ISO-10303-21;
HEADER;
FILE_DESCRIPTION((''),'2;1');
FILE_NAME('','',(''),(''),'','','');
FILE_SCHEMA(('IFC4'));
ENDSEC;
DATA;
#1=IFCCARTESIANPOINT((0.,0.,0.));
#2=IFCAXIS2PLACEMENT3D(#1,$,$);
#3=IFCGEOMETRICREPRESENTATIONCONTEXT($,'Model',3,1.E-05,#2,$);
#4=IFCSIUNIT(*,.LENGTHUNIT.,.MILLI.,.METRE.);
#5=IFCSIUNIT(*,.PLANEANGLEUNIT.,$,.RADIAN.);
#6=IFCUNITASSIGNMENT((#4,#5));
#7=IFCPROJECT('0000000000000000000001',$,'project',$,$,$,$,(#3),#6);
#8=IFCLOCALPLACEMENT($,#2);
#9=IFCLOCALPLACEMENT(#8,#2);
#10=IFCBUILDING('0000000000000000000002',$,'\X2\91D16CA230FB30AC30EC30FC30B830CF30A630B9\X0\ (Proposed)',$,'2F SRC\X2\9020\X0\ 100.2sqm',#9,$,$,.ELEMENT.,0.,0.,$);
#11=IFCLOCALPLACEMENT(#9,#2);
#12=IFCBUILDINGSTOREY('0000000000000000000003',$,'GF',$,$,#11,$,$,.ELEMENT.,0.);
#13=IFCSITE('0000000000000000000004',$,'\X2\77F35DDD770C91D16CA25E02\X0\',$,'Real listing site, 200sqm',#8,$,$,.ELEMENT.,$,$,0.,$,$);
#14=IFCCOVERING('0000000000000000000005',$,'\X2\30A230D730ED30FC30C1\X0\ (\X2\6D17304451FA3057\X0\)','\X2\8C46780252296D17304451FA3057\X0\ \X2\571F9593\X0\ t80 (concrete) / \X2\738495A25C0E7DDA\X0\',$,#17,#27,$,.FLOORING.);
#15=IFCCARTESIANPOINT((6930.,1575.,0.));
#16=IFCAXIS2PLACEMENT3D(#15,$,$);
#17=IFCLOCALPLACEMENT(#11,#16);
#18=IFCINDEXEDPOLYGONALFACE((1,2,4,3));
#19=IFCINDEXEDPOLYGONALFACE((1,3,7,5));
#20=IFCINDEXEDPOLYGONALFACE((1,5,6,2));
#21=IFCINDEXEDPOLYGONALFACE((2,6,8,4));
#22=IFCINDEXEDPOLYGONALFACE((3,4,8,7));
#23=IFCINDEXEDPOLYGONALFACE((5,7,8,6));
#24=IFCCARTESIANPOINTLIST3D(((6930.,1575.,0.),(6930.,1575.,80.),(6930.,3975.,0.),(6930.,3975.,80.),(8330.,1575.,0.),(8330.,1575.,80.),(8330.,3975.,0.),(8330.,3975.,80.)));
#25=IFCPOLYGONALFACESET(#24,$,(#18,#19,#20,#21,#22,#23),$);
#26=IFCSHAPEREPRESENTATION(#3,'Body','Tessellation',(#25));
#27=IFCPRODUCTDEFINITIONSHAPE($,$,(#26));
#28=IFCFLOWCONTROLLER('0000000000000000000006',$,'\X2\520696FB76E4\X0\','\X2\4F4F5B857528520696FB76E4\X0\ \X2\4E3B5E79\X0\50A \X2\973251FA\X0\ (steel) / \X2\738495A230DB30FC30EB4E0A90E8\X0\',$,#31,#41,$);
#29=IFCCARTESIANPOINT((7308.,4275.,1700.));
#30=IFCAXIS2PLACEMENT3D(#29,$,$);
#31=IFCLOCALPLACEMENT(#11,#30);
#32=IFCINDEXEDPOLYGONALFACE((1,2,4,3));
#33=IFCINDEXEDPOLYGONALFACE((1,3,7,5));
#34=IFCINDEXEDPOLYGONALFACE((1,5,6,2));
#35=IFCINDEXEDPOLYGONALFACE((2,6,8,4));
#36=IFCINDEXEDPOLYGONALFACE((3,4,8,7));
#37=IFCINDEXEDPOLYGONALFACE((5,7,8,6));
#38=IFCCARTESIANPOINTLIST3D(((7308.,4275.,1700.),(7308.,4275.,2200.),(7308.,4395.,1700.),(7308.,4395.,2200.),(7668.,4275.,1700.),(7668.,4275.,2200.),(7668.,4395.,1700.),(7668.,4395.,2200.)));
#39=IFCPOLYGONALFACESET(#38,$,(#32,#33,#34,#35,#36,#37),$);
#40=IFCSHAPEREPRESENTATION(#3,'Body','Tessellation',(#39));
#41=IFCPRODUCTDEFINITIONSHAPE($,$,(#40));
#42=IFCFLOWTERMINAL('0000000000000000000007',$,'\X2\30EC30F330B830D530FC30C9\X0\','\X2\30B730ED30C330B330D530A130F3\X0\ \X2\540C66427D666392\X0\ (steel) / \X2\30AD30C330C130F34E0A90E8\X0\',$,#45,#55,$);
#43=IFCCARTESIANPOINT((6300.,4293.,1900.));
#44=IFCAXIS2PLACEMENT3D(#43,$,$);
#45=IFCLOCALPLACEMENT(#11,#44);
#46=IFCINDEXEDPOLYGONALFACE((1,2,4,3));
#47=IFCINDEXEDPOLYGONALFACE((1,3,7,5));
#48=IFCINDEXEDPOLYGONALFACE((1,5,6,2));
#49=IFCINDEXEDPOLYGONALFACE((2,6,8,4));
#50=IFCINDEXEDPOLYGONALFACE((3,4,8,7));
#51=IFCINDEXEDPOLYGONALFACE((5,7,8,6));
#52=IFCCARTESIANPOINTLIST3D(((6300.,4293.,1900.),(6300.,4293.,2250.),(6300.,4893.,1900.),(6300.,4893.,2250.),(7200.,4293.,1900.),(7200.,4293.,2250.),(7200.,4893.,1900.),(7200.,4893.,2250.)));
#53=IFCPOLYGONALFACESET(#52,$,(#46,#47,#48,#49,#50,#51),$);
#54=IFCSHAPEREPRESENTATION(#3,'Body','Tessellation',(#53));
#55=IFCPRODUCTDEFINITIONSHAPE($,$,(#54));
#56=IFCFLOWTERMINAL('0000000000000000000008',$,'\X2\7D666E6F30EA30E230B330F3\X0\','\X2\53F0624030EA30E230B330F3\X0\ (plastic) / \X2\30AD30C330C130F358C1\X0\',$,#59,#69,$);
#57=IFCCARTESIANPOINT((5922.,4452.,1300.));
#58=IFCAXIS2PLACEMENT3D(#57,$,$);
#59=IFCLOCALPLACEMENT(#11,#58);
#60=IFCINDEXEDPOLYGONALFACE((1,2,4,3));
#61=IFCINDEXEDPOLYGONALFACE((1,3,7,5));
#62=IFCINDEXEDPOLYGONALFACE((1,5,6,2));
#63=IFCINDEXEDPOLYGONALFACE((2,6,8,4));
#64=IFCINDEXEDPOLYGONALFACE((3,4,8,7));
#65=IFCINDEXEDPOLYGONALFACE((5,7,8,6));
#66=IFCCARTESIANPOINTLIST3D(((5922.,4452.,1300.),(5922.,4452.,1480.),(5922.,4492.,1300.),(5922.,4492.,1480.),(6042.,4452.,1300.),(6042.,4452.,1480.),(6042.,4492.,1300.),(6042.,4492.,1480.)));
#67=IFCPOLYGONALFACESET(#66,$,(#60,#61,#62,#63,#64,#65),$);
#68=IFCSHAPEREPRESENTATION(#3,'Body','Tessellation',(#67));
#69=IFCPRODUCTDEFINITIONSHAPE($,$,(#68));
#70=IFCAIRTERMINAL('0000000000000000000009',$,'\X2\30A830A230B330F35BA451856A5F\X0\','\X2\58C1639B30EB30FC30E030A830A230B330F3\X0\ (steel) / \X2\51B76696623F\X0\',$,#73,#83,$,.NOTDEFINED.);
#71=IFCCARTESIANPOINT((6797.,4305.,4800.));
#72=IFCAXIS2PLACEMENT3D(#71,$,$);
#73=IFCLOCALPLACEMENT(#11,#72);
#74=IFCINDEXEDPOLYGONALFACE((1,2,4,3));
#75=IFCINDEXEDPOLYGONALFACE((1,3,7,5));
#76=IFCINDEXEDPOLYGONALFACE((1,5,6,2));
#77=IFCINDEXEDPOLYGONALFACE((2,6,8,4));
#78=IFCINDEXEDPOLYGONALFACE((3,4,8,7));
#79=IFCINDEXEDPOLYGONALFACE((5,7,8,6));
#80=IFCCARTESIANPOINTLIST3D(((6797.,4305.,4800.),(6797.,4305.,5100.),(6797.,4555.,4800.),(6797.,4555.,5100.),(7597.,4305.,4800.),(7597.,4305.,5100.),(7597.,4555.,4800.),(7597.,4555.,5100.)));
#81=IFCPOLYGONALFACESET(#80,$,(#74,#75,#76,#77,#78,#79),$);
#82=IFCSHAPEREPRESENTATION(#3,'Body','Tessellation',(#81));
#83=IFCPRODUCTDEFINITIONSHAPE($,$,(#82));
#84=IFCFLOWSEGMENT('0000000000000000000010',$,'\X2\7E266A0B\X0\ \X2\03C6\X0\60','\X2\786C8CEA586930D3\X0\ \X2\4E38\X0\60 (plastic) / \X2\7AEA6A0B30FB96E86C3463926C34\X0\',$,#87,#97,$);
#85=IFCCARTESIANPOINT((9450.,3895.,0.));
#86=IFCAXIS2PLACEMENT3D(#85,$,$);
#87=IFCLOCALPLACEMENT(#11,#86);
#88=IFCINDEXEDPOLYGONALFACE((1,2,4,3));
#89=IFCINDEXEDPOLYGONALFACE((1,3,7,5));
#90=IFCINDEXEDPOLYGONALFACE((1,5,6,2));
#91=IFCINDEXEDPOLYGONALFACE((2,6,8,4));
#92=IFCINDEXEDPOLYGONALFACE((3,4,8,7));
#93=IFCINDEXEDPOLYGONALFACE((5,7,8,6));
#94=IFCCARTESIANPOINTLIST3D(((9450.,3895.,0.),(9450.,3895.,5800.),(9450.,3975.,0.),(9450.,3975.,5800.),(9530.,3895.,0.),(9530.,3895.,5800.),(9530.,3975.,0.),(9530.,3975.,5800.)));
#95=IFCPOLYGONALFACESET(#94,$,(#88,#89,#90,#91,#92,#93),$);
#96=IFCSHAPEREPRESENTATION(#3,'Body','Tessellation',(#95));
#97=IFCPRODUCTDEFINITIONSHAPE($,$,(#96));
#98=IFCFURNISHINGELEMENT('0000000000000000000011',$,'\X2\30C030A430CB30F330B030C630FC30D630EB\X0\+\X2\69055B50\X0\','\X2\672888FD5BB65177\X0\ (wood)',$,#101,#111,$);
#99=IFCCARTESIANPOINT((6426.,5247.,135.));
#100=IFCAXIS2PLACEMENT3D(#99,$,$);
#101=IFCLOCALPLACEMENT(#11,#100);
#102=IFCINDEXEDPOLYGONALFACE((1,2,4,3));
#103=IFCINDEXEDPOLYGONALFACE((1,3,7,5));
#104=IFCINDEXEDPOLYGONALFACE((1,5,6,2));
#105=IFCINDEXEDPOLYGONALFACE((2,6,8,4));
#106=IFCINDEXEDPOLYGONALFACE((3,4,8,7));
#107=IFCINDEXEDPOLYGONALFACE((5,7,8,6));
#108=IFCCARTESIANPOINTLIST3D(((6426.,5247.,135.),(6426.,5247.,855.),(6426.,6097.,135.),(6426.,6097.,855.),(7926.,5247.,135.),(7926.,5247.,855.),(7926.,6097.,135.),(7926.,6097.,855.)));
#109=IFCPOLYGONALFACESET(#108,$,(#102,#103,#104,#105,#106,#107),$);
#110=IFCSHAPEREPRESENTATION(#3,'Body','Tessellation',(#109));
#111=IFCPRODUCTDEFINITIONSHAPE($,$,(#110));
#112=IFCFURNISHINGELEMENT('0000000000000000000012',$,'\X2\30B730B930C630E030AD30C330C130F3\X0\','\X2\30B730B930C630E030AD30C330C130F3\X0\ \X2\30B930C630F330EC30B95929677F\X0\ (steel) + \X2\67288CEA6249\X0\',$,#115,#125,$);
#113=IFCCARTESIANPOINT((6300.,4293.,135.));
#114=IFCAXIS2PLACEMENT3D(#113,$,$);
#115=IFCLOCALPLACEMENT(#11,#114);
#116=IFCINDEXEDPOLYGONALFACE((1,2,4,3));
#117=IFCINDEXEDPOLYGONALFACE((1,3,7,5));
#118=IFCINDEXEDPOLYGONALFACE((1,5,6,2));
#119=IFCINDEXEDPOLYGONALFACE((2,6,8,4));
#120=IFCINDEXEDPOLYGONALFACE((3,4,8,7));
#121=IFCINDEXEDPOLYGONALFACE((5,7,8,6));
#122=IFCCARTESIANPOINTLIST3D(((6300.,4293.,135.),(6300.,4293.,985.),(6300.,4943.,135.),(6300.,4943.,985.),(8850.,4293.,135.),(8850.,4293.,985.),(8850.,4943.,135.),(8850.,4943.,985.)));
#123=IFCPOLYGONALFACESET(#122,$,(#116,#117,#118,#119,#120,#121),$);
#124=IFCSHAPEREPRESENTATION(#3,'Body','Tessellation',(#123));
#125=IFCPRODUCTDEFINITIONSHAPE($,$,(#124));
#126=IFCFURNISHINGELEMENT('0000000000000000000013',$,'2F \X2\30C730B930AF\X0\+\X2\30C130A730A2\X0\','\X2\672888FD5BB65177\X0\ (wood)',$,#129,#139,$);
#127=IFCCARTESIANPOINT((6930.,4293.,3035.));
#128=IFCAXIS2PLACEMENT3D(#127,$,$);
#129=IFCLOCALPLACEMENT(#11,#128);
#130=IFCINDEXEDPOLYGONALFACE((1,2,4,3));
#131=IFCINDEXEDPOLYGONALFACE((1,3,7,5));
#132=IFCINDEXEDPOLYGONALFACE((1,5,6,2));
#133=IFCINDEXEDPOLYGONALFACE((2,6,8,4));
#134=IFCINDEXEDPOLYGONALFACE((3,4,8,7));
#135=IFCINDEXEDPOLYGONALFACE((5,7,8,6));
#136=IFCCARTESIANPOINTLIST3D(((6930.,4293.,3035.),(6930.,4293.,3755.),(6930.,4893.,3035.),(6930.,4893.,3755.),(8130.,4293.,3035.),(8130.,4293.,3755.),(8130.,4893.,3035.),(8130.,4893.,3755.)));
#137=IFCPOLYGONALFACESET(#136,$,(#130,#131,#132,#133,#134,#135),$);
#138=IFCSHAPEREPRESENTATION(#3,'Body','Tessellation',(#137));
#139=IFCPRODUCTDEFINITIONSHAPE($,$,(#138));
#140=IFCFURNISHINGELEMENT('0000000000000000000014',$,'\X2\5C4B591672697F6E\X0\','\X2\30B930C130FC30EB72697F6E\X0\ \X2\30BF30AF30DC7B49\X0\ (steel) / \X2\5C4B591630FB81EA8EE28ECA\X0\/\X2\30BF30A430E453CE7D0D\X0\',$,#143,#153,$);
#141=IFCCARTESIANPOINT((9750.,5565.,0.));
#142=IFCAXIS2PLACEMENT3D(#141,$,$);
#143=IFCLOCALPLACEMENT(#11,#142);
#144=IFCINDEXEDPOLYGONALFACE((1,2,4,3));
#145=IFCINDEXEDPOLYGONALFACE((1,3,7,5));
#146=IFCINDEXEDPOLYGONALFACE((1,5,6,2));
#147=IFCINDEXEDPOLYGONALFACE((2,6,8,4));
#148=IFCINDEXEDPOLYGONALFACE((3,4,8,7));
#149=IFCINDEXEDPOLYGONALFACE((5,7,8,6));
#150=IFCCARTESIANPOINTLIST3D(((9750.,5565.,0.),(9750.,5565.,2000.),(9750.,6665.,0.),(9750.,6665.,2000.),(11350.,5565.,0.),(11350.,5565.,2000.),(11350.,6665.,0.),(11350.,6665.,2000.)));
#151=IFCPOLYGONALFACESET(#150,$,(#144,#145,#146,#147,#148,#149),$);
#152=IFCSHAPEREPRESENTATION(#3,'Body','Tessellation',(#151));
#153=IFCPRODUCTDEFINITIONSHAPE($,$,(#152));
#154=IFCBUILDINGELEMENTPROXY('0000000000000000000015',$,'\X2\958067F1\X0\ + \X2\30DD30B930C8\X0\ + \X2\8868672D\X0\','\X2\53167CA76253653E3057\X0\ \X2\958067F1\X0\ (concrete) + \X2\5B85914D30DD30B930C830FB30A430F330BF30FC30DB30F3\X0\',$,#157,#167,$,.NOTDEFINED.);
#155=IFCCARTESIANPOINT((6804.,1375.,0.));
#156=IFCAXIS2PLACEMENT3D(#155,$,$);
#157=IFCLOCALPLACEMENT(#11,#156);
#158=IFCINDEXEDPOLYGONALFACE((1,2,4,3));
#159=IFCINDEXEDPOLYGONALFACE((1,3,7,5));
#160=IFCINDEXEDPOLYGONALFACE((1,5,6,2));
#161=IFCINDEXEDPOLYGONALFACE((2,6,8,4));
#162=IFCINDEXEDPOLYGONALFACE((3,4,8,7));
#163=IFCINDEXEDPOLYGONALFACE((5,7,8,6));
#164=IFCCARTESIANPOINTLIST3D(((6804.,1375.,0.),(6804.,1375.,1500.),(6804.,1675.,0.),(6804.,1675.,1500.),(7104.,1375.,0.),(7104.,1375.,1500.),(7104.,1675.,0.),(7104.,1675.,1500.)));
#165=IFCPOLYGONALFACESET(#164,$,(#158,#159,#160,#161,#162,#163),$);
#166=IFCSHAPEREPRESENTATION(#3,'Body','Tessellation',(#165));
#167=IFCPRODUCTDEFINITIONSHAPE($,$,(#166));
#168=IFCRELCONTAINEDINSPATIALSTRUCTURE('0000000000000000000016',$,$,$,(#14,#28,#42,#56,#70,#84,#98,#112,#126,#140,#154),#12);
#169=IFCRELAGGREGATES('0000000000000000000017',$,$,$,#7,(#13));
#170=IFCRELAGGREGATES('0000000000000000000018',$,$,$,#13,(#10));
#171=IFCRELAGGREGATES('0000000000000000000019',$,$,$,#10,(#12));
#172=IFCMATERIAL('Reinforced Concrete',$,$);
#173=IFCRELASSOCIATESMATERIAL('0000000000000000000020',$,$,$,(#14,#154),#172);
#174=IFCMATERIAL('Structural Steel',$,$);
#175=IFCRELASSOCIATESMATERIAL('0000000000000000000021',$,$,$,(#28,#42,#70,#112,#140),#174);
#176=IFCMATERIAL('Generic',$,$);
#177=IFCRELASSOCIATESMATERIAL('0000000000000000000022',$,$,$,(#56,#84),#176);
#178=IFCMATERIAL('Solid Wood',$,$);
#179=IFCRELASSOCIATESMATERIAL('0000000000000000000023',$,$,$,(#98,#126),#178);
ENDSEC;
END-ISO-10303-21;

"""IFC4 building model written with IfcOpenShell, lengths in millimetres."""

from ifc_helpers import new_model, si_unit, frame, frame_2d, origin, place, context, project, spatial, rectangle, extrude, material, element, save


model = new_model("IFC4")

# Units and contexts
model_context = context("Model", 3, precision=1e-05, world=origin())
ifc_project = project(units=[si_unit("LENGTHUNIT", "METRE", prefix="MILLI"), si_unit("PLANEANGLEUNIT", "RADIAN")], contexts=[model_context])

# Site, building, storey
site_placement = place(None, origin())
site = spatial("IfcSite", under=ifc_project, at=site_placement, Name="石川県金沢市", ObjectType="Real listing site, 200sqm", CompositionType="ELEMENT", RefElevation=0.0)
building_placement = place(site_placement, origin())
building = spatial("IfcBuilding", under=site, at=building_placement, Name="金沢・ガレージハウス (Proposed)", ObjectType="2F SRC造 100.2sqm", CompositionType="ELEMENT", ElevationOfRefHeight=0.0, ElevationOfTerrain=0.0)
storey_placement = place(building_placement, origin())
storey = spatial("IfcBuildingStorey", under=building, at=storey_placement, Name="GF", CompositionType="ELEMENT", Elevation=0.0)

# Shared definitions
ifc_material_1 = material(Name="Solid Wood")
ifc_material_2 = material(Name="Structural Steel")

# Shared definitions
ifc_material_3 = material(Name="Reinforced Concrete")

# Covering
covering_placement = place(storey_placement, frame((6930.0, 1575.0, 0.0)))
element("IfcCovering", 1, at=covering_placement, inside=storey, material=ifc_material_3, Name="アプローチ (洗い出し)", Description="豆砂利洗い出し 土間 t80 (concrete) / 玄関導線", PredefinedType="FLOORING", context=model_context, shape_type="SweptSolid", body=[
    extrude(rectangle(XDim=1400.0, YDim=2400.0, at=frame_2d((700.0, 1200.0))), frame((6930.0, 1575.0, 0.0)), (0.0, 0.0, 1.0), 80.0),
])

# Flow controller
flow_controller_placement = place(storey_placement, frame((7308.0, 4275.0, 1700.0)))
element("IfcFlowController", 2, at=flow_controller_placement, inside=storey, material=ifc_material_2, Name="分電盤", Description="住宅用分電盤 主幹50A 露出 (steel) / 玄関ホール上部", context=model_context, shape_type="SweptSolid", body=[
    extrude(rectangle(XDim=360.0, YDim=120.0, at=frame_2d((180.0, 60.0))), frame((7308.0, 4275.0, 1700.0)), (0.0, 0.0, 1.0), 500.0),
])

# Flow terminals
flow_terminal_1_placement = place(storey_placement, frame((6300.0, 4293.0, 1900.0)))
element("IfcFlowTerminal", 3, at=flow_terminal_1_placement, inside=storey, material=ifc_material_2, Name="レンジフード", Description="シロッコファン 同時給排 (steel) / キッチン上部", context=model_context, shape_type="SweptSolid", body=[
    extrude(rectangle(XDim=900.0, YDim=600.0, at=frame_2d((450.0, 300.0))), frame((6300.0, 4293.0, 1900.0)), (0.0, 0.0, 1.0), 350.0),
])
ifc_material_4 = material(Name="Generic")
flow_terminal_2_placement = place(storey_placement, frame((5922.0, 4452.0, 1300.0)))
element("IfcFlowTerminal", 4, at=flow_terminal_2_placement, inside=storey, material=ifc_material_4, Name="給湯リモコン", Description="台所リモコン (plastic) / キッチン壁", context=model_context, shape_type="SweptSolid", body=[
    extrude(rectangle(XDim=120.0, YDim=40.0, at=frame_2d((60.0, 20.0))), frame((5922.0, 4452.0, 1300.0)), (0.0, 0.0, 1.0), 180.0),
])

# Air terminal
air_terminal_placement = place(storey_placement, frame((6797.0, 4305.0, 4800.0)))
element("IfcAirTerminal", 5, at=air_terminal_placement, inside=storey, material=ifc_material_2, Name="エアコン室内機", Description="壁掛ルームエアコン (steel) / 冷暖房", PredefinedType="NOTDEFINED", context=model_context, shape_type="SweptSolid", body=[
    extrude(rectangle(XDim=800.0, YDim=250.0, at=frame_2d((400.0, 125.0))), frame((6797.0, 4305.0, 4800.0)), (0.0, 0.0, 1.0), 300.0),
])

# Flow segment
flow_segment_placement = place(storey_placement, frame((9450.0, 3895.0, 0.0)))
element("IfcFlowSegment", 6, at=flow_segment_placement, inside=storey, material=ifc_material_4, Name="縦樋 φ60", Description="硬質塩ビ 丸60 (plastic) / 竪樋・雨水排水", context=model_context, shape_type="SweptSolid", body=[
    extrude(rectangle(XDim=80.0, YDim=80.0, at=frame_2d((40.0, 40.0))), frame((9450.0, 3895.0, 0.0)), (0.0, 0.0, 1.0), 5800.0),
])

# Furnishing elements
furnishing_1_placement = place(storey_placement, frame((6426.0, 5247.0, 135.0)))
element("IfcFurnishingElement", 7, at=furnishing_1_placement, inside=storey, material=ifc_material_1, Name="ダイニングテーブル+椅子", Description="木製家具 (wood)", context=model_context, shape_type="SweptSolid", body=[
    extrude(rectangle(XDim=1500.0, YDim=850.0, at=frame_2d((750.0, 425.0))), frame((6426.0, 5247.0, 135.0)), (0.0, 0.0, 1.0), 720.0),
])
furnishing_2_placement = place(storey_placement, frame((6300.0, 4293.0, 135.0)))
element("IfcFurnishingElement", 8, at=furnishing_2_placement, inside=storey, material=ifc_material_2, Name="システムキッチン", Description="システムキッチン ステンレス天板 (steel) + 木質扉", context=model_context, shape_type="SweptSolid", body=[
    extrude(rectangle(XDim=2550.0, YDim=650.0, at=frame_2d((1275.0, 325.0))), frame((6300.0, 4293.0, 135.0)), (0.0, 0.0, 1.0), 850.0),
])
furnishing_3_placement = place(storey_placement, frame((6930.0, 4293.0, 3035.0)))
element("IfcFurnishingElement", 9, at=furnishing_3_placement, inside=storey, material=ifc_material_1, Name="2F デスク+チェア", Description="木製家具 (wood)", context=model_context, shape_type="SweptSolid", body=[
    extrude(rectangle(XDim=1200.0, YDim=600.0, at=frame_2d((600.0, 300.0))), frame((6930.0, 4293.0, 3035.0)), (0.0, 0.0, 1.0), 720.0),
])
furnishing_4_placement = place(storey_placement, frame((9750.0, 5565.0, 0.0)))
element("IfcFurnishingElement", 10, at=furnishing_4_placement, inside=storey, material=ifc_material_2, Name="屋外物置", Description="スチール物置 タクボ等 (steel) / 屋外・自転車/タイヤ収納", context=model_context, shape_type="SweptSolid", body=[
    extrude(rectangle(XDim=1600.0, YDim=1100.0, at=frame_2d((800.0, 550.0))), frame((9750.0, 5565.0, 0.0)), (0.0, 0.0, 1.0), 2000.0),
])

# Building element proxy
proxy_placement = place(storey_placement, frame((6804.0, 1375.0, 0.0)))
element("IfcBuildingElementProxy", 11, at=proxy_placement, inside=storey, material=ifc_material_3, Name="門柱 + ポスト + 表札", Description="化粧打放し 門柱 (concrete) + 宅配ポスト・インターホン", PredefinedType="NOTDEFINED", context=model_context, shape_type="SweptSolid", body=[
    extrude(rectangle(XDim=300.0, YDim=300.0, at=frame_2d((150.0, 150.0))), frame((6804.0, 1375.0, 0.0)), (0.0, 0.0, 1.0), 1500.0),
])

save(model, "model.ifc")
